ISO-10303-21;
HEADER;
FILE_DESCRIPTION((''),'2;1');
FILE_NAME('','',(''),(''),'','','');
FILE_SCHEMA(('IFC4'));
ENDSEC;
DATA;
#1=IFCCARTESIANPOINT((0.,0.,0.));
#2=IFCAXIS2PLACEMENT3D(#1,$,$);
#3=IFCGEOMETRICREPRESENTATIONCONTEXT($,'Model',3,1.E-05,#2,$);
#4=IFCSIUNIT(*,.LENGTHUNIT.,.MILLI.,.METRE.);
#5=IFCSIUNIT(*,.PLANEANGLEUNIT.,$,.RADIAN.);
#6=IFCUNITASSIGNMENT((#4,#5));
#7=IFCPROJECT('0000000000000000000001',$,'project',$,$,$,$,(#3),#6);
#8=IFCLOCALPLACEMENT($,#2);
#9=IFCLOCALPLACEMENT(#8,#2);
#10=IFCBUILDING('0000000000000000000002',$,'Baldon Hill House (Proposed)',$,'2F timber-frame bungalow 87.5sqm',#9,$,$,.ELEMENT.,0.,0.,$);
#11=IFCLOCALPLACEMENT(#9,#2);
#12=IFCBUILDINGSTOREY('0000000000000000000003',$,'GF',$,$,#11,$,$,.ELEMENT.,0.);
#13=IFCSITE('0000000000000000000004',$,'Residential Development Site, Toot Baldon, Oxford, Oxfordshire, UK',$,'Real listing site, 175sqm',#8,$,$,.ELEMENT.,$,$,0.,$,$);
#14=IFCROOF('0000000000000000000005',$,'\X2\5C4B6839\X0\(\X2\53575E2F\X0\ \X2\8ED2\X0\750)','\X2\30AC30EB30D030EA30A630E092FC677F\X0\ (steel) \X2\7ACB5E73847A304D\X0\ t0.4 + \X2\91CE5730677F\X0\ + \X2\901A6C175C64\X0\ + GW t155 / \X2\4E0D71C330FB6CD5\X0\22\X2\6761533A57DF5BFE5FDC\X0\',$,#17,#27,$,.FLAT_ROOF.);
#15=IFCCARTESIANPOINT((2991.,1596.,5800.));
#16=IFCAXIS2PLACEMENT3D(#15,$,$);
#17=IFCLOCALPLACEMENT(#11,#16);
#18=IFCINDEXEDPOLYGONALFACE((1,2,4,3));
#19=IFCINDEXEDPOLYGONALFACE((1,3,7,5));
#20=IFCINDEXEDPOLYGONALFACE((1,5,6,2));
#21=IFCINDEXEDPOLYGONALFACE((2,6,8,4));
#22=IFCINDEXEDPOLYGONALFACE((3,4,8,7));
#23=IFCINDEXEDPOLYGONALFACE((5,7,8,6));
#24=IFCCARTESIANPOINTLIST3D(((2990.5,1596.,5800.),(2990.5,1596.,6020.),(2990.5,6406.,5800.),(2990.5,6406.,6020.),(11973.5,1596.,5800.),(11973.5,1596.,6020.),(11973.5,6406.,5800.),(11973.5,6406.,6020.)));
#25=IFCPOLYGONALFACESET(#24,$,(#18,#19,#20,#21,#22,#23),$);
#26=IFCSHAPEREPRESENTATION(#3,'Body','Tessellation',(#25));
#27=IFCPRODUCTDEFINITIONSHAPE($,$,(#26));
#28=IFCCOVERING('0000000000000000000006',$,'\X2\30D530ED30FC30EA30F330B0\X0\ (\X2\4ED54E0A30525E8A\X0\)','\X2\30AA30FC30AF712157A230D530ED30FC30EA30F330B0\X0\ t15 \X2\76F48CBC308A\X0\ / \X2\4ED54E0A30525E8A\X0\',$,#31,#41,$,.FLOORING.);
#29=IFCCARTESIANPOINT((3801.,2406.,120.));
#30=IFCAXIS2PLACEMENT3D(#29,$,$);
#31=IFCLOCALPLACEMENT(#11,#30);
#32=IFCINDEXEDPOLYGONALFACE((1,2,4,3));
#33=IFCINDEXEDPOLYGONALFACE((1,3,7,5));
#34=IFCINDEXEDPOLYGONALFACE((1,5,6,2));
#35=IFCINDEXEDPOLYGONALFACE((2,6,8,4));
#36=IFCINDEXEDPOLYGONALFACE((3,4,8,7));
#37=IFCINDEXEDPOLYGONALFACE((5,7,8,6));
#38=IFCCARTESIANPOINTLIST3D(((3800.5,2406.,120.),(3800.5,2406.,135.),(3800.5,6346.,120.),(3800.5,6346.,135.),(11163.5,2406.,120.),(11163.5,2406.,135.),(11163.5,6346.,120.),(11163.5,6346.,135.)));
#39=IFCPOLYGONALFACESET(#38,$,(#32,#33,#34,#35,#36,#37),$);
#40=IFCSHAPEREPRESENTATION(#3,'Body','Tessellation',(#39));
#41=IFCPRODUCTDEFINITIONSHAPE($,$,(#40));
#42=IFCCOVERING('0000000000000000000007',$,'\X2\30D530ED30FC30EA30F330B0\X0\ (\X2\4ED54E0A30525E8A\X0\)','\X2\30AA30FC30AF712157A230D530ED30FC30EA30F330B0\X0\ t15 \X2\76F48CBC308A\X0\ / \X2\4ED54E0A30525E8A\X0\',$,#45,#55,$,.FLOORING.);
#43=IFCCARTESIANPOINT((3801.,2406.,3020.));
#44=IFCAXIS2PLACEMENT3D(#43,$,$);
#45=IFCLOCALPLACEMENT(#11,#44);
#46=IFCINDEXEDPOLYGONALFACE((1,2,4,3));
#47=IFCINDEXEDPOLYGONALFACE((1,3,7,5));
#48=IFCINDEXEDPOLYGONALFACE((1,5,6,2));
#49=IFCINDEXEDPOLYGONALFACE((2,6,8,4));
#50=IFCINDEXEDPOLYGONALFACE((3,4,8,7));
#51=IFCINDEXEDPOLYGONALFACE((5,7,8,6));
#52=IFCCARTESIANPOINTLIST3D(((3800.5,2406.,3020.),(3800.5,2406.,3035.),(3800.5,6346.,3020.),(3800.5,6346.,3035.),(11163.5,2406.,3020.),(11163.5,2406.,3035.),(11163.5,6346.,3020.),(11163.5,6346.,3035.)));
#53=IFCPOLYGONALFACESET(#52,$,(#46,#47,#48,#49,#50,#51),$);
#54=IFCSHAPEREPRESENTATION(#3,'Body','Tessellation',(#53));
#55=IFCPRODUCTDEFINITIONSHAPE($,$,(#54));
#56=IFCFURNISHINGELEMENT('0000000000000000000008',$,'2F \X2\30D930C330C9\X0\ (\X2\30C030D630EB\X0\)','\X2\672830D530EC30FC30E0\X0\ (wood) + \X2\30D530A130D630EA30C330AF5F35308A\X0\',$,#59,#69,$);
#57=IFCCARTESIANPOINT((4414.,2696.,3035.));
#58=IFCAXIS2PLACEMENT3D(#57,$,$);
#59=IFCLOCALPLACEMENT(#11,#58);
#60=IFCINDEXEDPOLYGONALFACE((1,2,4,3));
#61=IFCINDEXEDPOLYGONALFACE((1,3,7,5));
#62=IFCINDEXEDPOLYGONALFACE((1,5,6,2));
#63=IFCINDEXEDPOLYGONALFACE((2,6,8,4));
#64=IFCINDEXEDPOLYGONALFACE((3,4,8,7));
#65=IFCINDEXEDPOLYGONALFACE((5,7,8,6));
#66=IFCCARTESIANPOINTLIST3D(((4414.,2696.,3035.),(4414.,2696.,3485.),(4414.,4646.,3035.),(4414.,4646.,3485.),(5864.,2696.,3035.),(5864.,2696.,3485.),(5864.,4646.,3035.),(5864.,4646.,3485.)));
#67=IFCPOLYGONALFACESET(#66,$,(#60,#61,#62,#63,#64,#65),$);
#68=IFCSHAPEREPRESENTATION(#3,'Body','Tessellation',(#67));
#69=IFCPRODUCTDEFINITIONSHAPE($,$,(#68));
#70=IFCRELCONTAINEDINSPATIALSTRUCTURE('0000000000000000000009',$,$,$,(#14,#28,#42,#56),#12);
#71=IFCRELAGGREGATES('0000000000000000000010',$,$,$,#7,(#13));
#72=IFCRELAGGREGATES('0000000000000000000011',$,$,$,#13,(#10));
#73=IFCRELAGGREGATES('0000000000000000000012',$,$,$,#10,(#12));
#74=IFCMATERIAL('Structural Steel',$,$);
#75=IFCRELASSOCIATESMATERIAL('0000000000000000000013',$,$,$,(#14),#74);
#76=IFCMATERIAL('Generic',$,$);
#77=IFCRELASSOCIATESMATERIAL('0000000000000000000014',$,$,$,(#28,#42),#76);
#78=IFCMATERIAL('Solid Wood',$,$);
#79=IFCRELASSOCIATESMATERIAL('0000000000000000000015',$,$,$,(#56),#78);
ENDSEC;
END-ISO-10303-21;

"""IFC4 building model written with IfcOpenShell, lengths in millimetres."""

from ifc_helpers import new_model, si_unit, frame, frame_2d, origin, place, context, project, spatial, rectangle, extrude, material, element, save


model = new_model("IFC4")

# Units and contexts
model_context = context("Model", 3, precision=1e-05, world=origin())
ifc_project = project(units=[si_unit("LENGTHUNIT", "METRE", prefix="MILLI"), si_unit("PLANEANGLEUNIT", "RADIAN")], contexts=[model_context])

# Site, building, storey
site_placement = place(None, origin())
site = spatial("IfcSite", under=ifc_project, at=site_placement, Name="Residential Development Site, Toot Baldon, Oxford, Oxfordshire, UK", ObjectType="Real listing site, 175sqm", CompositionType="ELEMENT", RefElevation=0.0)
building_placement = place(site_placement, origin())
building = spatial("IfcBuilding", under=site, at=building_placement, Name="Baldon Hill House (Proposed)", ObjectType="2F timber-frame bungalow 87.5sqm", CompositionType="ELEMENT", ElevationOfRefHeight=0.0, ElevationOfTerrain=0.0)
storey_placement = place(building_placement, origin())
storey = spatial("IfcBuildingStorey", under=building, at=storey_placement, Name="GF", CompositionType="ELEMENT", Elevation=0.0)

# Shared definitions
ifc_material_1 = material(Name="Solid Wood")

# Roof
ifc_material_2 = material(Name="Structural Steel")
for number, where, name in (
    (1, (2991.0, 1596.0, 5800.0), "屋根(南帯 軒750)"),
):
    element("IfcRoof", number, at=place(storey_placement, frame(where)), inside=storey, material=ifc_material_2, Name=name, Description="ガルバリウム鋼板 (steel) 立平葺き t0.4 + 野地板 + 通気層 + GW t155 / 不燃・法22条区域対応", PredefinedType="FLAT_ROOF", context=model_context, shape_type="SweptSolid", body=[
        extrude(rectangle(XDim=8983.0, YDim=4810.0, at=frame_2d((4491.0, 2405.0))), frame((2991.0, 1596.0, 5800.0)), (0.0, 0.0, 1.0), 220.0),
    ])

# Coverings
ifc_material_3 = material(Name="Generic")
covering_1_placement = place(storey_placement, frame((3801.0, 2406.0, 120.0)))
element("IfcCovering", 2, at=covering_1_placement, inside=storey, material=ifc_material_3, Name="フローリング (仕上げ床)", Description="オーク無垢フローリング t15 直貼り / 仕上げ床", PredefinedType="FLOORING", context=model_context, shape_type="SweptSolid", body=[
    extrude(rectangle(XDim=7363.0, YDim=3940.0, at=frame_2d((3681.0, 1970.0))), frame((3801.0, 2406.0, 120.0)), (0.0, 0.0, 1.0), 15.0),
])
covering_2_placement = place(storey_placement, frame((3801.0, 2406.0, 3020.0)))
element("IfcCovering", 3, at=covering_2_placement, inside=storey, material=ifc_material_3, Name="フローリング (仕上げ床)", Description="オーク無垢フローリング t15 直貼り / 仕上げ床", PredefinedType="FLOORING", context=model_context, shape_type="SweptSolid", body=[
    extrude(rectangle(XDim=7363.0, YDim=3940.0, at=frame_2d((3681.0, 1970.0))), frame((3801.0, 2406.0, 3020.0)), (0.0, 0.0, 1.0), 15.0),
])

# Furnishing element
furnishing_placement = place(storey_placement, frame((4414.0, 2696.0, 3035.0)))
element("IfcFurnishingElement", 4, at=furnishing_placement, inside=storey, material=ifc_material_1, Name="2F ベッド (ダブル)", Description="木フレーム (wood) + ファブリック張り", context=model_context, shape_type="SweptSolid", body=[
    extrude(rectangle(XDim=1450.0, YDim=1950.0, at=frame_2d((725.0, 975.0))), frame((4414.0, 2696.0, 3035.0)), (0.0, 0.0, 1.0), 450.0),
])

save(model, "model.ifc")
